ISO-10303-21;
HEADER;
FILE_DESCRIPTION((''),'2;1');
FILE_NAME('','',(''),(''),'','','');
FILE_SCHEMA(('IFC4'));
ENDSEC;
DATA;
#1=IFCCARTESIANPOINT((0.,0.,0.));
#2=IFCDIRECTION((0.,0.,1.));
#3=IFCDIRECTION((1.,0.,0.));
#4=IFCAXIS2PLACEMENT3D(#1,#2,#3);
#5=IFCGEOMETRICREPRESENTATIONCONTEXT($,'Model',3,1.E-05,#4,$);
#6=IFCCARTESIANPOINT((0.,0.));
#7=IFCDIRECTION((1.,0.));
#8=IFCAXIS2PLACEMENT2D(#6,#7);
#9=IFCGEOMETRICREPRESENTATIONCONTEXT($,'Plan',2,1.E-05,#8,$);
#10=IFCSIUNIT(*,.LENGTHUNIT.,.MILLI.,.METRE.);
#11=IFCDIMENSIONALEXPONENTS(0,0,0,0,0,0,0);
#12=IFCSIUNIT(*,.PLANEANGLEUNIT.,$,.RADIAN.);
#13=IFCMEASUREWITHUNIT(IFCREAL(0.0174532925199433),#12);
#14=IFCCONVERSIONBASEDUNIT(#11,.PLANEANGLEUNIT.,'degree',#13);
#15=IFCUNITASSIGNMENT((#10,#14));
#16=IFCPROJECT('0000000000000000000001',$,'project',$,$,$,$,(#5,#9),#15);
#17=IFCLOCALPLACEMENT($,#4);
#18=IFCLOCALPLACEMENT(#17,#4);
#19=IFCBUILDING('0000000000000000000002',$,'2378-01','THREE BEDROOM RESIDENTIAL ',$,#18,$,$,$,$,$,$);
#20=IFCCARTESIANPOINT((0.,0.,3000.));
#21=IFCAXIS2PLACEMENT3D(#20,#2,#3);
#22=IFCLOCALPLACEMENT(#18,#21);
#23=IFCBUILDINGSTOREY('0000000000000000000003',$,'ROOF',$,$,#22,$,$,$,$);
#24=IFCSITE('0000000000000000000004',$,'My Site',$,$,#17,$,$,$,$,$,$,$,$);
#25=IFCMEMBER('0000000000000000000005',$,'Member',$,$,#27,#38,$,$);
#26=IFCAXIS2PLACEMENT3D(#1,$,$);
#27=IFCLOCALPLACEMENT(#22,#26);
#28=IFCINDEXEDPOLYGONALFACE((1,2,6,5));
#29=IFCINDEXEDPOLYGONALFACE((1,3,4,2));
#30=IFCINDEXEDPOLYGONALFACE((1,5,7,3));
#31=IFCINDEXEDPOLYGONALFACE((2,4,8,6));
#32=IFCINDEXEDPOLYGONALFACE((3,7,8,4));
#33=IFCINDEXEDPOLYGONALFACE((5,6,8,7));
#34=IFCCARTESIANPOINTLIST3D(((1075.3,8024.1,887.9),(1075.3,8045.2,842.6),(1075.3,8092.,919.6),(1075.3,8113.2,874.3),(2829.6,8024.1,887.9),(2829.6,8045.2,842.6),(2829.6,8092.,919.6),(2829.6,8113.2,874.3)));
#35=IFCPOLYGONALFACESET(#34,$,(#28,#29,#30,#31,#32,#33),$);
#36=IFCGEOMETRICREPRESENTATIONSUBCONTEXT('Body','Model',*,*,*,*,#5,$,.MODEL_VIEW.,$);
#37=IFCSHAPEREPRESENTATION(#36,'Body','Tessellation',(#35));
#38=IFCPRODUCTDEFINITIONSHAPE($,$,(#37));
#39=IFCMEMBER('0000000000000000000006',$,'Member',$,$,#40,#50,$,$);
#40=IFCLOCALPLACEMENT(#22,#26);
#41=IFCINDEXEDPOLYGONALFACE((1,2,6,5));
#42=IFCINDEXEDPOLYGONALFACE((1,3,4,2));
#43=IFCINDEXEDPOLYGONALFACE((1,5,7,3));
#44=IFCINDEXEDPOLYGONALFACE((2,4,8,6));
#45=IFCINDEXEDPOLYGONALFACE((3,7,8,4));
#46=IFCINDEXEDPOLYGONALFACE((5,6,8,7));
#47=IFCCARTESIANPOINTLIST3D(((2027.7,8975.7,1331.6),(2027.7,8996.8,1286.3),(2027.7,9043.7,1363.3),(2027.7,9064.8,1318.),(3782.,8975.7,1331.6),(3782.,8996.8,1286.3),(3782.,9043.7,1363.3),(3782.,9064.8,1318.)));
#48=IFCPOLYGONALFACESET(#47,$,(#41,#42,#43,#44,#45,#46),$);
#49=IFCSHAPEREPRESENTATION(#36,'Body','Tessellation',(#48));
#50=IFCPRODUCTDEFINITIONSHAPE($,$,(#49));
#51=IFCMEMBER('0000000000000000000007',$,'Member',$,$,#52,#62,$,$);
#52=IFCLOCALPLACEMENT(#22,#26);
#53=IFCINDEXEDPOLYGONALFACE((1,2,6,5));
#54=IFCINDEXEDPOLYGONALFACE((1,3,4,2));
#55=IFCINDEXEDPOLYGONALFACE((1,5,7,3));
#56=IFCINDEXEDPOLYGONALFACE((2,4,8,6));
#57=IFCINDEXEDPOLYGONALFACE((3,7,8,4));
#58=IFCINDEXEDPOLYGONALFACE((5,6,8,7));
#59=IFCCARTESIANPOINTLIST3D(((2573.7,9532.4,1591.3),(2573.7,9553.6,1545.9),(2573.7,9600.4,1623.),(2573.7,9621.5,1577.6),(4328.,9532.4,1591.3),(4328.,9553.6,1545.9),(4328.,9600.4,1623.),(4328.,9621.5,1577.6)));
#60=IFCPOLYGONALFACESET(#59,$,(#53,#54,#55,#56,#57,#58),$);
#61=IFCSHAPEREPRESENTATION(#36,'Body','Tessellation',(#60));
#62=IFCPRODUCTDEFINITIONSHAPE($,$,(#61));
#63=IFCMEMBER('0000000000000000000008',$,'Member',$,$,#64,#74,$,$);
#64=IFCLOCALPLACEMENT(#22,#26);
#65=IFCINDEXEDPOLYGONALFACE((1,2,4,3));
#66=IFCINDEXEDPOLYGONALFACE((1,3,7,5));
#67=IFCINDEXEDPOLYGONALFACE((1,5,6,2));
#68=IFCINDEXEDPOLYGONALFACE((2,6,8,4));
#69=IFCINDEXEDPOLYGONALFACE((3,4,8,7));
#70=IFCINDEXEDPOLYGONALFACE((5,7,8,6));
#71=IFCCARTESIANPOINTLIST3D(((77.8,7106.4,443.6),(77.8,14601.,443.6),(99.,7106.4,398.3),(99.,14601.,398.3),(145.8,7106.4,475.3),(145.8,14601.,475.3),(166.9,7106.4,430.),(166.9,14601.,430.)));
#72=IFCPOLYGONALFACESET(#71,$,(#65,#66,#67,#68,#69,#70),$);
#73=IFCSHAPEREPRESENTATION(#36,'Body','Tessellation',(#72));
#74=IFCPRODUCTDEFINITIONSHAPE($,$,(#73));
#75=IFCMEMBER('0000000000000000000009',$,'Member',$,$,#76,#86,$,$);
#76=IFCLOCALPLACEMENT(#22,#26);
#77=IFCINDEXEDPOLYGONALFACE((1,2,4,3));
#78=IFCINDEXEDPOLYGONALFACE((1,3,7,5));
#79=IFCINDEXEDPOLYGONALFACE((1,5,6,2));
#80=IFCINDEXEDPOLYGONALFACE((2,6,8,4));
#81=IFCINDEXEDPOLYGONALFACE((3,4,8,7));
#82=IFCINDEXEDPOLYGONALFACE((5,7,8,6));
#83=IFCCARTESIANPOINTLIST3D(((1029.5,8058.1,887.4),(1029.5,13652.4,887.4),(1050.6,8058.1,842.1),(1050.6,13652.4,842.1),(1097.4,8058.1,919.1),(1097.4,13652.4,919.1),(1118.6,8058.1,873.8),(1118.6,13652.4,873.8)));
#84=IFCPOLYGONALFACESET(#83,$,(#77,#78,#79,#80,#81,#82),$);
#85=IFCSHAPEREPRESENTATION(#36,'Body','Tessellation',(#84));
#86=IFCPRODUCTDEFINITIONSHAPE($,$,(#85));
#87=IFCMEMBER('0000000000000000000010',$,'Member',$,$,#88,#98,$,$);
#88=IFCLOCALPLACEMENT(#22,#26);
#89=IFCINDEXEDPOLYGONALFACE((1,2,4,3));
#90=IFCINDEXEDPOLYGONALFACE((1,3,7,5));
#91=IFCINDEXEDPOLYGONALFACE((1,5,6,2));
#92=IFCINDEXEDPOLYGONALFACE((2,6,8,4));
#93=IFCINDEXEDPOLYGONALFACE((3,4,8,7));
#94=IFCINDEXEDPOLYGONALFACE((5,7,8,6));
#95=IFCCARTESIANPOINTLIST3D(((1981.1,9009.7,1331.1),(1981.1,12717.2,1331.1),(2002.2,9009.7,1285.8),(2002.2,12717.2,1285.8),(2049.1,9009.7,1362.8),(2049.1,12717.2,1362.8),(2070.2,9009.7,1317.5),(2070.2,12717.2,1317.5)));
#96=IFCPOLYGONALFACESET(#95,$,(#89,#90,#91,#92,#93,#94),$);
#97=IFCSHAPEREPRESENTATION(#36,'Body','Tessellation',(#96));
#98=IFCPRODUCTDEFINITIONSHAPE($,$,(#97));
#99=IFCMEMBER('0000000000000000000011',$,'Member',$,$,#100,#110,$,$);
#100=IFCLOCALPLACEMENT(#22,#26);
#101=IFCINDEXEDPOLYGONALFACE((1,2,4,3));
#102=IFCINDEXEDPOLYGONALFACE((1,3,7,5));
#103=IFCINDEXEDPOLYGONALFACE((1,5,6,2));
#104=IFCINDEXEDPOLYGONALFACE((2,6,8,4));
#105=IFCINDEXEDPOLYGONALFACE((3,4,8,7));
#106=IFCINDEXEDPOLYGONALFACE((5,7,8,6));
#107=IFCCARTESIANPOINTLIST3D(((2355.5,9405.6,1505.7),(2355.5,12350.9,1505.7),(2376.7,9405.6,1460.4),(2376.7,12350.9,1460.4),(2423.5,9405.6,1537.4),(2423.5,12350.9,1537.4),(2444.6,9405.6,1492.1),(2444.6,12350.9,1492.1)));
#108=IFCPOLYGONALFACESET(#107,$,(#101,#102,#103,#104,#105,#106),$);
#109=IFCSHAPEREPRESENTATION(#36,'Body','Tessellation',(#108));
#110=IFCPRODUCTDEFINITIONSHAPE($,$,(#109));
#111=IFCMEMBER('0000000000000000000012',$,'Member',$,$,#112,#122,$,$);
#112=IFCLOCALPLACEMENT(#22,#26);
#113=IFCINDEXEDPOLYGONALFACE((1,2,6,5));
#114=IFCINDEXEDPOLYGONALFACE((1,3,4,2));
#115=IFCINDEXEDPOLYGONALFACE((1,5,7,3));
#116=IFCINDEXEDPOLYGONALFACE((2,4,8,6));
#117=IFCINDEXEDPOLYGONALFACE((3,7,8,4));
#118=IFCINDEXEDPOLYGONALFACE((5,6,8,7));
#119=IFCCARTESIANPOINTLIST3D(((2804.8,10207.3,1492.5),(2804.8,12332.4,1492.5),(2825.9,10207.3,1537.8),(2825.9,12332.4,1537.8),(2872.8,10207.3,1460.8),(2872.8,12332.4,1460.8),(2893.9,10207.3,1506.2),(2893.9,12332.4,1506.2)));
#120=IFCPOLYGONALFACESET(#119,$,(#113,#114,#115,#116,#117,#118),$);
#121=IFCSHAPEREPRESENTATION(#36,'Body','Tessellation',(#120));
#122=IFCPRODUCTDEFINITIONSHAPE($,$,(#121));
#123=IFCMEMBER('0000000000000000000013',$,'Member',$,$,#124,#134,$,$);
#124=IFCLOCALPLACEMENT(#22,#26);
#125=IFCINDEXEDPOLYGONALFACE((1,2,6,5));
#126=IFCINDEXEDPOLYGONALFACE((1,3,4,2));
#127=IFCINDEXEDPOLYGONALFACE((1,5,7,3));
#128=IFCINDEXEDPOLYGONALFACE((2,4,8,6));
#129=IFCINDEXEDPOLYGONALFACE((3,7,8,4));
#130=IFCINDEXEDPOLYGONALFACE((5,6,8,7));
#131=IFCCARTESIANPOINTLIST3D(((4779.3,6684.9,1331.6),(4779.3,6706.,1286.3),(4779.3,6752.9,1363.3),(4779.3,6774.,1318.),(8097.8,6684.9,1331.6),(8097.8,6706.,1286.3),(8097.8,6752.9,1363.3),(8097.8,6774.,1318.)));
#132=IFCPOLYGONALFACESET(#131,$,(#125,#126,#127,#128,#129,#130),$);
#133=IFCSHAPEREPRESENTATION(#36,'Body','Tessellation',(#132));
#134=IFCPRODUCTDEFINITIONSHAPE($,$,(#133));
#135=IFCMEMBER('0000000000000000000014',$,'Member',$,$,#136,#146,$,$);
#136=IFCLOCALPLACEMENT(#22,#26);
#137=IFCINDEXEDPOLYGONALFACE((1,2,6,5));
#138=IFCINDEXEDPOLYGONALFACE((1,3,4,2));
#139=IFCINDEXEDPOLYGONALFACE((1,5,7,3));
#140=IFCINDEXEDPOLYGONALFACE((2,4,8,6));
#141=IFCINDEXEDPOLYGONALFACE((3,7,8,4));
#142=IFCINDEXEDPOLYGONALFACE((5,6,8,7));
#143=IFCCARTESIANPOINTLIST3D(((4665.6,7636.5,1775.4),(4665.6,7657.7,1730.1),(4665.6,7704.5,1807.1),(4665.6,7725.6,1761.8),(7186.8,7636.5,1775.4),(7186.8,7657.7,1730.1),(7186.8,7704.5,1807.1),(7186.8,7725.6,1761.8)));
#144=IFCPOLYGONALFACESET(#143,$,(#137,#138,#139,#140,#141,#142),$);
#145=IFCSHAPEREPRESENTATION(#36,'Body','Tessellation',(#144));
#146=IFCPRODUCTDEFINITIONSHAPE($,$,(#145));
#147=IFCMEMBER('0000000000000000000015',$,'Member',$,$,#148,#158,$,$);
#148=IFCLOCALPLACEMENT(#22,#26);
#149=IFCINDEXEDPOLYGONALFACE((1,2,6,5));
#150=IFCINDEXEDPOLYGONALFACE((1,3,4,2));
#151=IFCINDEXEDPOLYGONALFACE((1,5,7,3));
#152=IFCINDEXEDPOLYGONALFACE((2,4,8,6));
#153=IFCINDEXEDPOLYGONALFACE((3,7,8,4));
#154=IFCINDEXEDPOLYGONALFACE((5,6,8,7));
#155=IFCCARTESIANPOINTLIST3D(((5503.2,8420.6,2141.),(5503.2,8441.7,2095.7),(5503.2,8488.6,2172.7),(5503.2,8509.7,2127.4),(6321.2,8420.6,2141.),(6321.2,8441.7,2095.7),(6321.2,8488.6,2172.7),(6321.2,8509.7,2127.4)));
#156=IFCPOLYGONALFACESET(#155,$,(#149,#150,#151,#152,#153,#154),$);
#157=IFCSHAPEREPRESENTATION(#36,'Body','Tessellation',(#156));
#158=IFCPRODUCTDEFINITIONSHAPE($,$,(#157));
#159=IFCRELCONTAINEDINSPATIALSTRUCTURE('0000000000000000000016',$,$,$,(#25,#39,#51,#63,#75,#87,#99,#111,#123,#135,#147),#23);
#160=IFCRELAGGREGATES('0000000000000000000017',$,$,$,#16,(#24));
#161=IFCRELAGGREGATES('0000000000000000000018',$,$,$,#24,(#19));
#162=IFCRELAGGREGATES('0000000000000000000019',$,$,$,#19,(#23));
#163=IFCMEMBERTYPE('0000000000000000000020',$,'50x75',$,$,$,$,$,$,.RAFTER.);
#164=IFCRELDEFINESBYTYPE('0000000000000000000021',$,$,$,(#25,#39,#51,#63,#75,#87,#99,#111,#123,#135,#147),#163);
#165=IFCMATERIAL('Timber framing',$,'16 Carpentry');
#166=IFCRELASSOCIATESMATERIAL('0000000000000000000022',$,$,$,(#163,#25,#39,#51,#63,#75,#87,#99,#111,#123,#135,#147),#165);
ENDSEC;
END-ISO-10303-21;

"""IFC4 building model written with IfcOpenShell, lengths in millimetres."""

from ifc_helpers import new_model, entity, si_unit, converted_unit, frame, origin_with_axes, origin_2d_with_axis, place, context, subcontext, project, spatial, rectangle, extrude, material, material_profile, profile_set, profile_usage, type_object, element, save


model = new_model("IFC4")

# Units and contexts
model_context = context("Model", 3, precision=1e-05, world=origin_with_axes())
plan_context = context("Plan", 2, precision=1e-05, world=origin_2d_with_axis())
body_context = subcontext(model_context, "Body", "Model", "MODEL_VIEW")
ifc_project = project(units=[si_unit("LENGTHUNIT", "METRE", prefix="MILLI"), converted_unit("PLANEANGLEUNIT", "degree", entity("IfcReal", 0.0174532925199433), si_unit("PLANEANGLEUNIT", "RADIAN"), dimensions=[0, 0, 0, 0, 0, 0, 0])], contexts=[model_context, plan_context])

# Site, building, storey
site_placement = place(None, origin_with_axes())
site = spatial("IfcSite", under=ifc_project, at=site_placement, Name="My Site")
building_placement = place(site_placement, origin_with_axes())
building = spatial("IfcBuilding", under=site, at=building_placement, Name="2378-01", Description="THREE BEDROOM RESIDENTIAL ")
storey_placement = place(building_placement, frame((0.0, 0.0, 3000.0), z_axis=(0.0, 0.0, 1.0), x_axis=(1.0, 0.0, 0.0)))
storey = spatial("IfcBuildingStorey", under=building, at=storey_placement, Name="ROOF")

# Members
ifc_material_1 = material(Name="Timber framing", Category="16 Carpentry")
ifc_material_profile_1 = material_profile(ifc_material_1, rectangle(XDim=50.0, YDim=75.0), Name="Lumber2", Category="Substrate", Priority=2)
ifc_profile_set_1 = profile_set([ifc_material_profile_1])
member_type_1 = type_object("IfcMemberType", Name="50x75", PredefinedType="RAFTER", material=ifc_profile_set_1)
ifc_profile_usage_1 = profile_usage(ifc_profile_set_1, cardinal=5)
member_1_placement = place(storey_placement, frame((2829.6, 8068.6, 881.1), z_axis=(-1.0, 0.0, 0.0), x_axis=(0.0, -0.422618, 0.906308)))
element("IfcMember", 1, at=member_1_placement, inside=storey, type_object=member_type_1, material=ifc_profile_usage_1, Name="Member", context=body_context, shape_type="SweptSolid", body=[
    extrude(rectangle(XDim=50.0, YDim=75.0), origin_with_axes(), (0.0, 0.0, 1.0), 1754.3),
])
ifc_profile_usage_2 = profile_usage(ifc_profile_set_1, cardinal=5)
member_2_placement = place(storey_placement, frame((3782.0, 9020.2, 1324.8), z_axis=(-1.0, 0.0, 0.0), x_axis=(0.0, -0.422618, 0.906308)))
element("IfcMember", 2, at=member_2_placement, inside=storey, type_object=member_type_1, material=ifc_profile_usage_2, Name="Member", context=body_context, shape_type="SweptSolid", body=[
    extrude(rectangle(XDim=50.0, YDim=75.0), origin_with_axes(), (0.0, 0.0, 1.0), 1754.3),
])
ifc_profile_usage_3 = profile_usage(ifc_profile_set_1, cardinal=5)
member_3_placement = place(storey_placement, frame((4328.0, 9577.0, 1584.4), z_axis=(-1.0, 0.0, 0.0), x_axis=(0.0, -0.422618, 0.906308)))
element("IfcMember", 3, at=member_3_placement, inside=storey, type_object=member_type_1, material=ifc_profile_usage_3, Name="Member", context=body_context, shape_type="SweptSolid", body=[
    extrude(rectangle(XDim=50.0, YDim=75.0), origin_with_axes(), (0.0, 0.0, 1.0), 1754.3),
])
ifc_profile_usage_4 = profile_usage(ifc_profile_set_1, cardinal=5)
member_4_placement = place(storey_placement, frame((122.4, 7106.4, 436.8), z_axis=(0.0, 1.0, 0.0), x_axis=(-0.422618, 0.0, 0.906308)))
element("IfcMember", 4, at=member_4_placement, inside=storey, type_object=member_type_1, material=ifc_profile_usage_4, Name="Member", context=body_context, shape_type="SweptSolid", body=[
    extrude(rectangle(XDim=50.0, YDim=75.0), origin_with_axes(), (0.0, 0.0, 1.0), 7494.6),
])
ifc_profile_usage_5 = profile_usage(ifc_profile_set_1, cardinal=5)
member_5_placement = place(storey_placement, frame((1074.0, 8058.1, 880.6), z_axis=(0.0, 1.0, 0.0), x_axis=(-0.422618, 0.0, 0.906308)))
element("IfcMember", 5, at=member_5_placement, inside=storey, type_object=member_type_1, material=ifc_profile_usage_5, Name="Member", context=body_context, shape_type="SweptSolid", body=[
    extrude(rectangle(XDim=50.0, YDim=75.0), origin_with_axes(), (0.0, 0.0, 1.0), 5594.4),
])
ifc_profile_usage_6 = profile_usage(ifc_profile_set_1, cardinal=5)
member_6_placement = place(storey_placement, frame((2025.6, 9009.7, 1324.3), z_axis=(0.0, 1.0, 0.0), x_axis=(-0.422618, 0.0, 0.906308)))
element("IfcMember", 6, at=member_6_placement, inside=storey, type_object=member_type_1, material=ifc_profile_usage_6, Name="Member", context=body_context, shape_type="SweptSolid", body=[
    extrude(rectangle(XDim=50.0, YDim=75.0), origin_with_axes(), (0.0, 0.0, 1.0), 3707.6),
])
ifc_profile_usage_7 = profile_usage(ifc_profile_set_1, cardinal=5)
member_7_placement = place(storey_placement, frame((2400.1, 9405.6, 1498.9), z_axis=(0.0, 1.0, 0.0), x_axis=(-0.422618, 0.0, 0.906308)))
element("IfcMember", 7, at=member_7_placement, inside=storey, type_object=member_type_1, material=ifc_profile_usage_7, Name="Member", context=body_context, shape_type="SweptSolid", body=[
    extrude(rectangle(XDim=50.0, YDim=75.0), origin_with_axes(), (0.0, 0.0, 1.0), 2945.3),
])
ifc_profile_usage_8 = profile_usage(ifc_profile_set_1, cardinal=5)
member_8_placement = place(storey_placement, frame((2849.3, 10207.3, 1499.3), z_axis=(0.0, 1.0, 0.0), x_axis=(-0.422618, 0.0, -0.906308)))
element("IfcMember", 8, at=member_8_placement, inside=storey, type_object=member_type_1, material=ifc_profile_usage_8, Name="Member", context=body_context, shape_type="SweptSolid", body=[
    extrude(rectangle(XDim=50.0, YDim=75.0), origin_with_axes(), (0.0, 0.0, 1.0), 2125.1),
])
ifc_profile_usage_9 = profile_usage(ifc_profile_set_1, cardinal=5)
member_9_placement = place(storey_placement, frame((4779.3, 6729.4, 1324.8), z_axis=(1.0, 0.0, 0.0), x_axis=(0.0, 0.422618, -0.906308)))
element("IfcMember", 9, at=member_9_placement, inside=storey, type_object=member_type_1, material=ifc_profile_usage_9, Name="Member", context=body_context, shape_type="SweptSolid", body=[
    extrude(rectangle(XDim=50.0, YDim=75.0), origin_with_axes(), (0.0, 0.0, 1.0), 3318.5),
])
ifc_profile_usage_10 = profile_usage(ifc_profile_set_1, cardinal=5)
member_10_placement = place(storey_placement, frame((4665.6, 7681.1, 1768.6), z_axis=(1.0, 0.0, 0.0), x_axis=(0.0, 0.422618, -0.906308)))
element("IfcMember", 10, at=member_10_placement, inside=storey, type_object=member_type_1, material=ifc_profile_usage_10, Name="Member", context=body_context, shape_type="SweptSolid", body=[
    extrude(rectangle(XDim=50.0, YDim=75.0), origin_with_axes(), (0.0, 0.0, 1.0), 2521.1),
])
ifc_profile_usage_11 = profile_usage(ifc_profile_set_1, cardinal=5)
member_11_placement = place(storey_placement, frame((5503.2, 8465.1, 2134.2), z_axis=(1.0, 0.0, 0.0), x_axis=(0.0, 0.422618, -0.906308)))
element("IfcMember", 11, at=member_11_placement, inside=storey, type_object=member_type_1, material=ifc_profile_usage_11, Name="Member", context=body_context, shape_type="SweptSolid", body=[
    extrude(rectangle(XDim=50.0, YDim=75.0), origin_with_axes(), (0.0, 0.0, 1.0), 817.9),
])

save(model, "model.ifc")
